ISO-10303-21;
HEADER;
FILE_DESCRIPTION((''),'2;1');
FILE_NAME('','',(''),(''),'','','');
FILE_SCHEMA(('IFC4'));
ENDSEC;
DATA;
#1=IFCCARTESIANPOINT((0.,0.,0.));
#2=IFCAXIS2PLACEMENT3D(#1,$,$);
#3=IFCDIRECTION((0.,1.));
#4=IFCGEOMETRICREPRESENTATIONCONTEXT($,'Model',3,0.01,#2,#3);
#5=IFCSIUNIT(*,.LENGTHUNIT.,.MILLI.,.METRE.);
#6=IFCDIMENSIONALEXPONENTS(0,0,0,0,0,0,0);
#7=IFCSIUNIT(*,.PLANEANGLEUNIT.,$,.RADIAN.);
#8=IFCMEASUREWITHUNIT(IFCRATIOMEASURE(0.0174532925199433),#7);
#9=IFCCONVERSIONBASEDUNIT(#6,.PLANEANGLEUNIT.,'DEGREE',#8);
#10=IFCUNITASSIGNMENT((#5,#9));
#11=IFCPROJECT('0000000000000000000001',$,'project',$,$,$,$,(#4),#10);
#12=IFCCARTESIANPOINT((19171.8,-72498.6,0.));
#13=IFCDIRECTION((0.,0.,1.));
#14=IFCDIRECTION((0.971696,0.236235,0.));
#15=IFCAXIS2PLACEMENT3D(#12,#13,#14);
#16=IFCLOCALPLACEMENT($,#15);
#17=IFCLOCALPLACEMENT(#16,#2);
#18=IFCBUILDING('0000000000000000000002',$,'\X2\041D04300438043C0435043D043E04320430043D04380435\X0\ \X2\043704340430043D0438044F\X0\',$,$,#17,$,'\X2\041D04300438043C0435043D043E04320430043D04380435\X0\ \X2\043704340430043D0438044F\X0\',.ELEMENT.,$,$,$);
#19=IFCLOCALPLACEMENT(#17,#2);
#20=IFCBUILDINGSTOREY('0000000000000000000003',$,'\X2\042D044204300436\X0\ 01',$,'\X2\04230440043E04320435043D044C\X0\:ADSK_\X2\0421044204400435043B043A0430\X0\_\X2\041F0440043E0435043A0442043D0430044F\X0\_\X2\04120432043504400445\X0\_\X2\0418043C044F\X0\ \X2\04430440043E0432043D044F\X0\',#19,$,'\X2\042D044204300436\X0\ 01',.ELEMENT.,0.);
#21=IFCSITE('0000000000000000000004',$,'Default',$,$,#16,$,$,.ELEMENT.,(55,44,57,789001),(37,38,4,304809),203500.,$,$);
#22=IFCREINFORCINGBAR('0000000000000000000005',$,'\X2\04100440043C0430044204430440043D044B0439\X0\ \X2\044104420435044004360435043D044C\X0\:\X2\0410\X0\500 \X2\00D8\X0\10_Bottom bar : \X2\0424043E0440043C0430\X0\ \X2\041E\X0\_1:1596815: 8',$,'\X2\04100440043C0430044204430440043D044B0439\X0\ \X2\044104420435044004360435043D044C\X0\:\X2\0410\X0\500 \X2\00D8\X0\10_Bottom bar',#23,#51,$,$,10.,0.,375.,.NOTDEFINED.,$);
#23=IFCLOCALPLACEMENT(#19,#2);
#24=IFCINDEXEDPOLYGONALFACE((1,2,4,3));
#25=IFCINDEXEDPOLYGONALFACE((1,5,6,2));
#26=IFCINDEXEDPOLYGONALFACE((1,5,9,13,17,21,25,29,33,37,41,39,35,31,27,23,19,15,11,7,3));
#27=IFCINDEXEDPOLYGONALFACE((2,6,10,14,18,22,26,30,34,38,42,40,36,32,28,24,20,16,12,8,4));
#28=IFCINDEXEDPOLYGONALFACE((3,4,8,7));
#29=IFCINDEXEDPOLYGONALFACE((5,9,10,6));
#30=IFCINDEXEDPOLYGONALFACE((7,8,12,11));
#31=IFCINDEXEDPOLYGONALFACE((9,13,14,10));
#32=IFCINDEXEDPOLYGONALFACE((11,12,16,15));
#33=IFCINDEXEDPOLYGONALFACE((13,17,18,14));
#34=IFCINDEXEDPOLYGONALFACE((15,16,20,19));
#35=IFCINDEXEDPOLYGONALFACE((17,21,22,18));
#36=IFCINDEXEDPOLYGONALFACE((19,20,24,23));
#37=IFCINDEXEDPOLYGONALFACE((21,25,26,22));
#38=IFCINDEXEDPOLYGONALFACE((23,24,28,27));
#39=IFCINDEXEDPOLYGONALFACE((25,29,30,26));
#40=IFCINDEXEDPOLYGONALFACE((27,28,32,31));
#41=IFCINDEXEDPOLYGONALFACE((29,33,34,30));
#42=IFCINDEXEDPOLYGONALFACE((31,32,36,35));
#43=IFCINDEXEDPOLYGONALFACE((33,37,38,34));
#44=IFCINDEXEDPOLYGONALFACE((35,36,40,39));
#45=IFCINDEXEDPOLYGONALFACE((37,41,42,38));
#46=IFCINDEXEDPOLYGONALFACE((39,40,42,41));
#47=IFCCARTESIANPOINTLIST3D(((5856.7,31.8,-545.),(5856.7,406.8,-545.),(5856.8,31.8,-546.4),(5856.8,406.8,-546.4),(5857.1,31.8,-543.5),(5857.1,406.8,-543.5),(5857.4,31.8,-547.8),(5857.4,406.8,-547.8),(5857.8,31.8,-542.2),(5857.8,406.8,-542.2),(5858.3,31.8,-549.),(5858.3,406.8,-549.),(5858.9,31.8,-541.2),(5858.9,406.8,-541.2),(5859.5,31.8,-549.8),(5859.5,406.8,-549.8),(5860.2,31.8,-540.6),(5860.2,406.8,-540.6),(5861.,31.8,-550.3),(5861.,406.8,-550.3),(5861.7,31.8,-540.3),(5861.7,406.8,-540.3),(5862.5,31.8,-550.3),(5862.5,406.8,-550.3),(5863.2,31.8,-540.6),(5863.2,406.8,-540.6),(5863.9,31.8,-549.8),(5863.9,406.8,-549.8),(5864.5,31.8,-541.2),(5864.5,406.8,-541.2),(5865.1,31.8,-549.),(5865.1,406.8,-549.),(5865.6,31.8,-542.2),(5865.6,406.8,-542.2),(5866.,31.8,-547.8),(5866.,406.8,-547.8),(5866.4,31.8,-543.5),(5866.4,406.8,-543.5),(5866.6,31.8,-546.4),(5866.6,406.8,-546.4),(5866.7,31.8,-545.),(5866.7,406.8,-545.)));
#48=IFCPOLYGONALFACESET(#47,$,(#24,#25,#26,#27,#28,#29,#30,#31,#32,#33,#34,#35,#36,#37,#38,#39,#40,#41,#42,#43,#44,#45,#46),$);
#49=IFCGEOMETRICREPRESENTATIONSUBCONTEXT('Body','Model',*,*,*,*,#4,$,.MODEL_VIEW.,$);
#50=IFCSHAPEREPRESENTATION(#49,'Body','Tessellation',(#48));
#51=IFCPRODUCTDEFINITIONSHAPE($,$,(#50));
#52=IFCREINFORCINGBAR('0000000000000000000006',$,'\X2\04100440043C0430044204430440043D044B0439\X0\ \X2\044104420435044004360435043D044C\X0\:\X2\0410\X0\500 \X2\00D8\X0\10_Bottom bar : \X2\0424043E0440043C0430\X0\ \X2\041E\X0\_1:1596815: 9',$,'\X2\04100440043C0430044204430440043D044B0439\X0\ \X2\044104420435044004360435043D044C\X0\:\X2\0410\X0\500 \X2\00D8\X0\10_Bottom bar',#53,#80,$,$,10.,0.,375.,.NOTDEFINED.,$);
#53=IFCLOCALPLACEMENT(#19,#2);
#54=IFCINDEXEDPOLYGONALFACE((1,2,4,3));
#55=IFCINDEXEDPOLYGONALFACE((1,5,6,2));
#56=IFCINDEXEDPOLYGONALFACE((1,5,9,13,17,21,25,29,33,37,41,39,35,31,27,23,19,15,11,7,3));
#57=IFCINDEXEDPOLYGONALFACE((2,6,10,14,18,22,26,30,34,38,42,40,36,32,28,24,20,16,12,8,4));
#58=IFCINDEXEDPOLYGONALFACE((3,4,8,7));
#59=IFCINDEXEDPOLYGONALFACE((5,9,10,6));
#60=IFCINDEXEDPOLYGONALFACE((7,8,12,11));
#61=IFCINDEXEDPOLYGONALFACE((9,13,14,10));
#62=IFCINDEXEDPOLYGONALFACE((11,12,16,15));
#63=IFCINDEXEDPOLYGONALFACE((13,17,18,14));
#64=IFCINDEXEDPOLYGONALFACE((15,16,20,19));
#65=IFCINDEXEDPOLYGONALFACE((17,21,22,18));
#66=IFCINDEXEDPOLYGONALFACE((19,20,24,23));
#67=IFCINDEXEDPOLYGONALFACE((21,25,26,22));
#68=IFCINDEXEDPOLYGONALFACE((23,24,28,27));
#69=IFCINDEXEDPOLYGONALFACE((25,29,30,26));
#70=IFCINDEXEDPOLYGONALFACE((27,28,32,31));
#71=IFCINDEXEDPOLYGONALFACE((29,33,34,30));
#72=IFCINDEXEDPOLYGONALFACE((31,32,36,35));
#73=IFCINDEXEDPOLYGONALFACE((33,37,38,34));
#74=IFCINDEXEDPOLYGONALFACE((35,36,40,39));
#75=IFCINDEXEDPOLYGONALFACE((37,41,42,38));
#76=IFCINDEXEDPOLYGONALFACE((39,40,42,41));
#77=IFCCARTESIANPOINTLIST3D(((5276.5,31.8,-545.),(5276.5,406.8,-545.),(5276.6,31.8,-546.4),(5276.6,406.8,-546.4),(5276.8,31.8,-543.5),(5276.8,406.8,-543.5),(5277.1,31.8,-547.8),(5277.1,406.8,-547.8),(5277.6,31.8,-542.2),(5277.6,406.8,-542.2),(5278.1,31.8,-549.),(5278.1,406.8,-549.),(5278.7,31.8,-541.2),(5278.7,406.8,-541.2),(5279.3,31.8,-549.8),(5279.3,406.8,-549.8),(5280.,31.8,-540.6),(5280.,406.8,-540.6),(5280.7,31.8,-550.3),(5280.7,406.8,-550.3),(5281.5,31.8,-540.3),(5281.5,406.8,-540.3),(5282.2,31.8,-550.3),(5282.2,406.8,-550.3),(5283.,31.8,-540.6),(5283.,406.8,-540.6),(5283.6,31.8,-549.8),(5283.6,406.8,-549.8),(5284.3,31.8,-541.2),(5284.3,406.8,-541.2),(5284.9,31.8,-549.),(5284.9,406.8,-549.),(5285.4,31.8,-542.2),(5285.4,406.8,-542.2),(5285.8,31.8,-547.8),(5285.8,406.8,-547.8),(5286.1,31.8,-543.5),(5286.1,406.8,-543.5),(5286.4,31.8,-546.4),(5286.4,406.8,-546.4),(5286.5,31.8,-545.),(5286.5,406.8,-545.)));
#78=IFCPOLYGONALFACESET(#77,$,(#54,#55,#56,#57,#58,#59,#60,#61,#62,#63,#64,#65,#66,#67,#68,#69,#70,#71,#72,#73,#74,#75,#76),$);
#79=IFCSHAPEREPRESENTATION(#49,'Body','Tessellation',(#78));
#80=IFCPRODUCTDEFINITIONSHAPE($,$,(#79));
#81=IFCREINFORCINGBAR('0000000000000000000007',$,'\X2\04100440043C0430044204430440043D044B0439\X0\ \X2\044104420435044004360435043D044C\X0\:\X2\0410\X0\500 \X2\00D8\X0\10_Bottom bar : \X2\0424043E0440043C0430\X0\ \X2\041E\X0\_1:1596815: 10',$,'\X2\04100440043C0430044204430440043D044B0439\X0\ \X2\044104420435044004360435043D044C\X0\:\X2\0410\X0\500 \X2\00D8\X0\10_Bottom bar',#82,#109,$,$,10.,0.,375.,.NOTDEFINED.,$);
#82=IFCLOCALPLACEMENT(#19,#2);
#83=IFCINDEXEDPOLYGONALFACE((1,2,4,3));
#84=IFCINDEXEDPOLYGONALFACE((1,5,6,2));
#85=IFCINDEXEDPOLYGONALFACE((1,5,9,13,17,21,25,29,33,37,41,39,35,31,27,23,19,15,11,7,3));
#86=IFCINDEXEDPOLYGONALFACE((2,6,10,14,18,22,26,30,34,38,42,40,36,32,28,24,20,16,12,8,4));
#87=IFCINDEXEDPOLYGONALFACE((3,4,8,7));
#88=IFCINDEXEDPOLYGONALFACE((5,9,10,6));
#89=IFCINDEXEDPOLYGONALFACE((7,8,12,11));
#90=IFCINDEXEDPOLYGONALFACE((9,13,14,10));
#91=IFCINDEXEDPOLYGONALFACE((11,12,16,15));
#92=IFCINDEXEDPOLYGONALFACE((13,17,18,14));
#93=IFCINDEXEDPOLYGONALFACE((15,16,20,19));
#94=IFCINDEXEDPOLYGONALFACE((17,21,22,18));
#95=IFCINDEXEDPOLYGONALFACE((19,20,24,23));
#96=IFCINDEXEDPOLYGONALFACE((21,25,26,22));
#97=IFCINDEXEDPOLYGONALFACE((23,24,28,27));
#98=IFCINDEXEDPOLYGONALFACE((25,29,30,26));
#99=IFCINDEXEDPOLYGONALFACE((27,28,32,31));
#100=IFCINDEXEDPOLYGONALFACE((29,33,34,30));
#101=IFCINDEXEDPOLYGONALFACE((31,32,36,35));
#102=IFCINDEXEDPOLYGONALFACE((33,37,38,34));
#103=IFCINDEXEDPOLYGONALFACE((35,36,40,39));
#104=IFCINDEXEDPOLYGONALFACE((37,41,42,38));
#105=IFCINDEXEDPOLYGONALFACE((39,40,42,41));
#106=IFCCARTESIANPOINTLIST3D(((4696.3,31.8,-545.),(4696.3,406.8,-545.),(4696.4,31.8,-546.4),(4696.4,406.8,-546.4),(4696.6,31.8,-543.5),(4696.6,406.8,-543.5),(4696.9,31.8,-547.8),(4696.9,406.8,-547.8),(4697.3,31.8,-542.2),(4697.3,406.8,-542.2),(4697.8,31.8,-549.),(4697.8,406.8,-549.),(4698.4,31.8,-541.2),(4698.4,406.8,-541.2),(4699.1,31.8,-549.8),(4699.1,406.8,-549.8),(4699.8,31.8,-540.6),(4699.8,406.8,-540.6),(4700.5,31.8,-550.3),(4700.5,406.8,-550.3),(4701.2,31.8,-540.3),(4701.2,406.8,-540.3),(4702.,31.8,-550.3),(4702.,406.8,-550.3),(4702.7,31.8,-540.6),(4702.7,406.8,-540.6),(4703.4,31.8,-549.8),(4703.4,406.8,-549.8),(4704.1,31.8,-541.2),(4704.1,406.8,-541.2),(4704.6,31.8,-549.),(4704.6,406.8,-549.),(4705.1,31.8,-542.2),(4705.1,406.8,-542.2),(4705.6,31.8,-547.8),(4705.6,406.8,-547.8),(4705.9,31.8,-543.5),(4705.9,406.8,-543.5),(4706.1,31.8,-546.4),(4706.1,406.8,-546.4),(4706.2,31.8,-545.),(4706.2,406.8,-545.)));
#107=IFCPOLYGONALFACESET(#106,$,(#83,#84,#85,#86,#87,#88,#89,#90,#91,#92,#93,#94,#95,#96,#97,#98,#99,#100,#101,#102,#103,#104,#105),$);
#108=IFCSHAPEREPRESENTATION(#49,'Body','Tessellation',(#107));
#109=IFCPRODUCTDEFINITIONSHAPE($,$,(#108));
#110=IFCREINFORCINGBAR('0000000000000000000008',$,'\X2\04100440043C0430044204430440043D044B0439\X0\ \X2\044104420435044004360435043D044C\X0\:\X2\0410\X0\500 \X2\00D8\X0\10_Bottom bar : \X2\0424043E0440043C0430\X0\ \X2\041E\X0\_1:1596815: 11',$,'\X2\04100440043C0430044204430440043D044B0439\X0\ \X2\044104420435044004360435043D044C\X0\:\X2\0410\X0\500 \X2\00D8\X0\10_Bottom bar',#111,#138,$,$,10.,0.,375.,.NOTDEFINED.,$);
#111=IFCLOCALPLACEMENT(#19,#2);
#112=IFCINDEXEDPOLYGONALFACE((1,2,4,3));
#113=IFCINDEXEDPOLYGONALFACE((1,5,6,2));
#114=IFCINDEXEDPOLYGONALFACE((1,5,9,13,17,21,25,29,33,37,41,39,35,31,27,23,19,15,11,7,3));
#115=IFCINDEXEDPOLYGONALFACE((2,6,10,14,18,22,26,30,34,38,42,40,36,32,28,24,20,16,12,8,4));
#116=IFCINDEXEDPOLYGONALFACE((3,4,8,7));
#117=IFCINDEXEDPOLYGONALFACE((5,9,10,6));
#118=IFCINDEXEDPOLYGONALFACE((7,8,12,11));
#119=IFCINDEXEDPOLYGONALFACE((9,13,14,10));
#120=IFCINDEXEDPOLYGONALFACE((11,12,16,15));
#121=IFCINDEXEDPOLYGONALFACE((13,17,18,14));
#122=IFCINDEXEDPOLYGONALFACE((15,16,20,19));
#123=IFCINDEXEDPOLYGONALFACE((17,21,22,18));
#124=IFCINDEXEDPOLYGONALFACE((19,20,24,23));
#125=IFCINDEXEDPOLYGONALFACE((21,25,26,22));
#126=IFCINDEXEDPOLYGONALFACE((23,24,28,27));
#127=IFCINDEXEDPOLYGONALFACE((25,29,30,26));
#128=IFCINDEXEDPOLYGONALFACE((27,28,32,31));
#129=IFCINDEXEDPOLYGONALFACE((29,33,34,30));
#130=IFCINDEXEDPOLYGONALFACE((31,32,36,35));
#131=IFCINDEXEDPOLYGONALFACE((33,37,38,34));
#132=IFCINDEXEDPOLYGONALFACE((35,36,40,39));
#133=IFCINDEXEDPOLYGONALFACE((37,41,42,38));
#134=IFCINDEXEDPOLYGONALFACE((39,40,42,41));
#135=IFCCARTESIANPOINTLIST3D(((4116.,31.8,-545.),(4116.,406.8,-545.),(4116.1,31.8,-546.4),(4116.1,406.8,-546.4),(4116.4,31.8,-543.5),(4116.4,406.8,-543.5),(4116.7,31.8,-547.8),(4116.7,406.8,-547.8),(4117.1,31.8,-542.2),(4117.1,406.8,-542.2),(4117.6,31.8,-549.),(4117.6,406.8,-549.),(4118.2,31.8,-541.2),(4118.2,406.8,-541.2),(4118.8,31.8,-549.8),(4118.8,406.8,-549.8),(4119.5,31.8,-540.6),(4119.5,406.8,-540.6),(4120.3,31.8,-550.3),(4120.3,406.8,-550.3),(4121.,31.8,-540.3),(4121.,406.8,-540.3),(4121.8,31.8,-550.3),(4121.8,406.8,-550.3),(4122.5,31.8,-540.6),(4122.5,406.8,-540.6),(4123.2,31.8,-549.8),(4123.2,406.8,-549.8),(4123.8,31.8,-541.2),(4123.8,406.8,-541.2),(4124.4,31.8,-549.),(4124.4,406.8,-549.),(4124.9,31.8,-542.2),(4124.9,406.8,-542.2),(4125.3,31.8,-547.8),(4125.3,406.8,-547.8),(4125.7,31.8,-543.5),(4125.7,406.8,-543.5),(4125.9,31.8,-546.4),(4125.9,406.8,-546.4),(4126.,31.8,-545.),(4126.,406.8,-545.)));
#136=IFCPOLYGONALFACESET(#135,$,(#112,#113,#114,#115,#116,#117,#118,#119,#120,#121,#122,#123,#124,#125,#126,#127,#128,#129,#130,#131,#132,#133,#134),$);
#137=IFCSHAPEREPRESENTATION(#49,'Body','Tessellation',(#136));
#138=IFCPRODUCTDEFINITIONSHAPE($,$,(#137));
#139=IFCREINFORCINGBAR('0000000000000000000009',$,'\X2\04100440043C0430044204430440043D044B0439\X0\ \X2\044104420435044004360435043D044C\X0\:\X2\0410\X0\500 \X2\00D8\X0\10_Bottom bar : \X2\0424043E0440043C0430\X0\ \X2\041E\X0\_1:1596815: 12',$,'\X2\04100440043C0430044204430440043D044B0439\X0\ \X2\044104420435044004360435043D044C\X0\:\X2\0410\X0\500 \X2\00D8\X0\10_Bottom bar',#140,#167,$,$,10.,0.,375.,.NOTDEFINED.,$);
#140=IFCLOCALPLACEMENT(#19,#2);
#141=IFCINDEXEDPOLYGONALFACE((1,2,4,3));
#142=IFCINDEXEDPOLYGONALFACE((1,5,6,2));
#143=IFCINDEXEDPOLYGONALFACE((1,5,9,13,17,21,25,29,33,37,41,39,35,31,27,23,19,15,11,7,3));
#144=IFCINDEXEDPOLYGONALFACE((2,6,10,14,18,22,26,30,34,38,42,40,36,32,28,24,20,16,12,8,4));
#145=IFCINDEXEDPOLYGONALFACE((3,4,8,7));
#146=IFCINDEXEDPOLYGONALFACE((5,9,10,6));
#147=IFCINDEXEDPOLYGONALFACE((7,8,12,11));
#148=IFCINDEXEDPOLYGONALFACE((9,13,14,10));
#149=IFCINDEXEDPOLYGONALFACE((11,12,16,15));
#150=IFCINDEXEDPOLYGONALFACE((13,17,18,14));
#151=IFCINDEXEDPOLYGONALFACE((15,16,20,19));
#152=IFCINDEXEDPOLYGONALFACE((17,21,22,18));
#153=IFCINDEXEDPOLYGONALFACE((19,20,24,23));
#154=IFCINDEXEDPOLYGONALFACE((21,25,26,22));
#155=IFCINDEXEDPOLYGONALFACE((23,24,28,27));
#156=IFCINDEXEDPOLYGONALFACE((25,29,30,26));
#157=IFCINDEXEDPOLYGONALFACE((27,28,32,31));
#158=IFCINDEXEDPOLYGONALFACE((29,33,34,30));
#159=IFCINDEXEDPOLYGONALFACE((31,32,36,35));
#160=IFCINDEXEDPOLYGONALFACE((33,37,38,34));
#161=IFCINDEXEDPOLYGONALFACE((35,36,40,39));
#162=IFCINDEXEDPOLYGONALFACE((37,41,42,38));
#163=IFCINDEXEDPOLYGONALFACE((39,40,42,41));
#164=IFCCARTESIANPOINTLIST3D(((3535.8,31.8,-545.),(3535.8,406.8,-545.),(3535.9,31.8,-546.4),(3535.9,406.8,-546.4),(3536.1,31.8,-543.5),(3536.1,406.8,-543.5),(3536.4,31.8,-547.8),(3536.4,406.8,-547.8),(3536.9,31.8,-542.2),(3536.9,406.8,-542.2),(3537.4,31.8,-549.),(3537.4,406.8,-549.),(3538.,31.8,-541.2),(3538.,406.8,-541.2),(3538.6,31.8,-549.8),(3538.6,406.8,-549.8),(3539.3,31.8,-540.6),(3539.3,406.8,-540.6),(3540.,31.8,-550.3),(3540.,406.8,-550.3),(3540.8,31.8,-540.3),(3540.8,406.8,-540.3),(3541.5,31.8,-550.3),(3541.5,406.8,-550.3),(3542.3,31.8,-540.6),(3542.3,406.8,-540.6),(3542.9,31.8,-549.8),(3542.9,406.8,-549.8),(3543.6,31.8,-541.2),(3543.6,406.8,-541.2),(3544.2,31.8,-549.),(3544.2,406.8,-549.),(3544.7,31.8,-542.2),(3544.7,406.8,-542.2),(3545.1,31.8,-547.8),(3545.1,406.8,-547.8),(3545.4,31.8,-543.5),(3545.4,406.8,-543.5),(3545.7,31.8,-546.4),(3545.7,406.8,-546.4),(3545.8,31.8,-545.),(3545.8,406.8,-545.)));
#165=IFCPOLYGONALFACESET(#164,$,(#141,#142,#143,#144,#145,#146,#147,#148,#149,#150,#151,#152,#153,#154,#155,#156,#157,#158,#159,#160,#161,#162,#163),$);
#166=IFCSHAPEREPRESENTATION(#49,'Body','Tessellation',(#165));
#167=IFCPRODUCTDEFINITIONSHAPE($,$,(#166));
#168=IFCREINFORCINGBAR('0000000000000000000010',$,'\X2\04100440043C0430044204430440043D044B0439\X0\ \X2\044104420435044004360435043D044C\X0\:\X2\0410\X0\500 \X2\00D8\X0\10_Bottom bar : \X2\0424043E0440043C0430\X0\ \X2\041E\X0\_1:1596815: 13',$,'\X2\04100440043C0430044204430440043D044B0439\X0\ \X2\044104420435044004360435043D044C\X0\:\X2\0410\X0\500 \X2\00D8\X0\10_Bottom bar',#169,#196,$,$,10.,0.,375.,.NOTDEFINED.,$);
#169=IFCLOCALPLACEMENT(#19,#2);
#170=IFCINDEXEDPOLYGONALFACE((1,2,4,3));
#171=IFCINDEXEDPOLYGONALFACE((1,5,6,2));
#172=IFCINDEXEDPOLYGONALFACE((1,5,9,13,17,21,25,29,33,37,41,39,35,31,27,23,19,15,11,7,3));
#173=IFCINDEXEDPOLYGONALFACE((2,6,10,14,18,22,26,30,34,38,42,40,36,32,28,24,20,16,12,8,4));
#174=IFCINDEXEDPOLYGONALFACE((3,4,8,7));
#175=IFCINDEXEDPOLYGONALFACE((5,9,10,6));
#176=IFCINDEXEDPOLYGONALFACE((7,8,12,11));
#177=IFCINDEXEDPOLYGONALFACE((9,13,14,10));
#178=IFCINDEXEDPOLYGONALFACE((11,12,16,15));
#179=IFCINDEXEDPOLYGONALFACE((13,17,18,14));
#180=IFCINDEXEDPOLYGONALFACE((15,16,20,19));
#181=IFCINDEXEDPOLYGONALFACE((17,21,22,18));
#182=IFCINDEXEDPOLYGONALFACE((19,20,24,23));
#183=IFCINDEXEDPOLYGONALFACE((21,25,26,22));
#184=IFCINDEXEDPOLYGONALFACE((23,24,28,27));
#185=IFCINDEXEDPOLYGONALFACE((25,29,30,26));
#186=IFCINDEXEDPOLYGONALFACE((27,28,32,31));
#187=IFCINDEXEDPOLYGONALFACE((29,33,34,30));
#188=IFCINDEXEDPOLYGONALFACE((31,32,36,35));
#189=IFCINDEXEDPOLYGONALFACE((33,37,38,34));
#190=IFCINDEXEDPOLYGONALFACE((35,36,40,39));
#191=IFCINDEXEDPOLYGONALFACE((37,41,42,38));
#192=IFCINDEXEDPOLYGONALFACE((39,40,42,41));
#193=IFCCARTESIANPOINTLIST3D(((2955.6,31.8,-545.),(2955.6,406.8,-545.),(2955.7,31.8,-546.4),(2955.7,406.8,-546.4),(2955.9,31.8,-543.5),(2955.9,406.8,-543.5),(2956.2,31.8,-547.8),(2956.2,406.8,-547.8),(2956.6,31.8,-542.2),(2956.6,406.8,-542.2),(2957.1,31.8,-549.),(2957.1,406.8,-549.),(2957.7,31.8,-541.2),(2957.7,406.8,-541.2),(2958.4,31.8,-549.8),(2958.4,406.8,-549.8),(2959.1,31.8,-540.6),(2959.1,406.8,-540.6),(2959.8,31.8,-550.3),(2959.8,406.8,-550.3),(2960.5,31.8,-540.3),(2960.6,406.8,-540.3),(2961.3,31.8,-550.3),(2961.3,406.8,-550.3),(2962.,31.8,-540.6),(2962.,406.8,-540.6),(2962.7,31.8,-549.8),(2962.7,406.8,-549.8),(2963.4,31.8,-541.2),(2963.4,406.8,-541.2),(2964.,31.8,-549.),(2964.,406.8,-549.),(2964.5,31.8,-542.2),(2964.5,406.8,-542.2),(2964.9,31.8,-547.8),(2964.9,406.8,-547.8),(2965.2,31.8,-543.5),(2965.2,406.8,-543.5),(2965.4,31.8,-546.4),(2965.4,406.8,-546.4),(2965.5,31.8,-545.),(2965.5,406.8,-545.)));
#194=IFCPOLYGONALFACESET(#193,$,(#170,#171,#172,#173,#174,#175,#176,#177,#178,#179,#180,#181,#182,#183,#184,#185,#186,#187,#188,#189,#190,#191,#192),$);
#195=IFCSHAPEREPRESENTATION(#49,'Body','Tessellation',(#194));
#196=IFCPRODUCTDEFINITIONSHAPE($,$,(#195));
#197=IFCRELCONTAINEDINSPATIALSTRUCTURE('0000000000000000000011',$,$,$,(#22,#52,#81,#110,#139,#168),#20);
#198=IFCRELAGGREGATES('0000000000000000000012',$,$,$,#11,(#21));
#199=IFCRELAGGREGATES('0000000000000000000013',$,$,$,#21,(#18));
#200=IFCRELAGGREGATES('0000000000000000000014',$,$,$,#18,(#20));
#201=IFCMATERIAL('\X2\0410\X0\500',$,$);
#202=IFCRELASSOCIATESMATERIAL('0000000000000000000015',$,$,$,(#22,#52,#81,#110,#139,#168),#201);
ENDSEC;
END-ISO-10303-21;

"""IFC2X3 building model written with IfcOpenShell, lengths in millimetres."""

from ifc_helpers import new_model, entity, si_unit, converted_unit, direction, frame, origin, place, context, subcontext, project, spatial, material, element, save


model = new_model("IFC2X3")

# Units and contexts
model_context = context("Model", 3, precision=0.01, world=origin(), true_north=direction((0.0, 1.0)))
body_context = subcontext(model_context, "Body", "Model", "MODEL_VIEW")
ifc_project = project(units=[si_unit("LENGTHUNIT", "METRE", prefix="MILLI"), converted_unit("PLANEANGLEUNIT", "DEGREE", entity("IfcRatioMeasure", 0.0174532925199433), si_unit("PLANEANGLEUNIT", "RADIAN"), dimensions=[0, 0, 0, 0, 0, 0, 0])], contexts=[model_context])

# Site, building, storey
site_placement = place(None, frame((19171.8, -72498.6, 0.0), z_axis=(0.0, 0.0, 1.0), x_axis=(0.971696, 0.236235, 0.0)))
site = spatial("IfcSite", under=ifc_project, at=site_placement, Name="Default", CompositionType="ELEMENT", RefLatitude=(55, 44, 57, 789001), RefLongitude=(37, 38, 4, 304809), RefElevation=203500.0)
building_placement = place(site_placement, origin())
building = spatial("IfcBuilding", under=site, at=building_placement, Name="Наименование здания", LongName="Наименование здания", CompositionType="ELEMENT")
storey_placement = place(building_placement, origin())
storey = spatial("IfcBuildingStorey", under=building, at=storey_placement, Name="Этаж 01", ObjectType="Уровень:ADSK_Стрелка_Проектная_Вверх_Имя уровня", LongName="Этаж 01", CompositionType="ELEMENT", Elevation=0.0)

# Reinforcing bars
ifc_material = material(Name="А500")
placement = place(storey_placement, origin())
element("IfcReinforcingBar", 1, at=placement, inside=storey, material=ifc_material, Name="Арматурный стержень:А500 Ø10_Bottom bar : Форма О_1:1596815: 8", ObjectType="Арматурный стержень:А500 Ø10_Bottom bar", BarLength=375.0, BarRole="NOTDEFINED", CrossSectionArea=0.0, NominalDiameter=10.0, context=body_context, shape_type="AdvancedSweptSolid", body=[
    entity("IfcSweptDiskSolid", entity("IfcCompositeCurve", [entity("IfcCompositeCurveSegment", "CONTINUOUS", True, entity("IfcPolyline", [entity("IfcCartesianPoint", [5861.7, 31.8, -545.3]), entity("IfcCartesianPoint", [5861.7, 406.8, -545.3])]))], False), 5.0, None, 0.0, 1.0),
])
element("IfcReinforcingBar", 2, at=placement, inside=storey, material=ifc_material, Name="Арматурный стержень:А500 Ø10_Bottom bar : Форма О_1:1596815: 9", ObjectType="Арматурный стержень:А500 Ø10_Bottom bar", BarLength=375.0, BarRole="NOTDEFINED", CrossSectionArea=0.0, NominalDiameter=10.0, context=body_context, shape_type="AdvancedSweptSolid", body=[
    entity("IfcSweptDiskSolid", entity("IfcCompositeCurve", [entity("IfcCompositeCurveSegment", "CONTINUOUS", True, entity("IfcPolyline", [entity("IfcCartesianPoint", [5281.5, 31.8, -545.3]), entity("IfcCartesianPoint", [5281.5, 406.8, -545.3])]))], False), 5.0, None, 0.0, 1.0),
])
element("IfcReinforcingBar", 3, at=placement, inside=storey, material=ifc_material, Name="Арматурный стержень:А500 Ø10_Bottom bar : Форма О_1:1596815: 10", ObjectType="Арматурный стержень:А500 Ø10_Bottom bar", BarLength=375.0, BarRole="NOTDEFINED", CrossSectionArea=0.0, NominalDiameter=10.0, context=body_context, shape_type="AdvancedSweptSolid", body=[
    entity("IfcSweptDiskSolid", entity("IfcCompositeCurve", [entity("IfcCompositeCurveSegment", "CONTINUOUS", True, entity("IfcPolyline", [entity("IfcCartesianPoint", [4701.2, 31.8, -545.3]), entity("IfcCartesianPoint", [4701.2, 406.8, -545.3])]))], False), 5.0, None, 0.0, 1.0),
])
element("IfcReinforcingBar", 4, at=placement, inside=storey, material=ifc_material, Name="Арматурный стержень:А500 Ø10_Bottom bar : Форма О_1:1596815: 11", ObjectType="Арматурный стержень:А500 Ø10_Bottom bar", BarLength=375.0, BarRole="NOTDEFINED", CrossSectionArea=0.0, NominalDiameter=10.0, context=body_context, shape_type="AdvancedSweptSolid", body=[
    entity("IfcSweptDiskSolid", entity("IfcCompositeCurve", [entity("IfcCompositeCurveSegment", "CONTINUOUS", True, entity("IfcPolyline", [entity("IfcCartesianPoint", [4121.0, 31.8, -545.3]), entity("IfcCartesianPoint", [4121.0, 406.8, -545.3])]))], False), 5.0, None, 0.0, 1.0),
])
element("IfcReinforcingBar", 5, at=placement, inside=storey, material=ifc_material, Name="Арматурный стержень:А500 Ø10_Bottom bar : Форма О_1:1596815: 12", ObjectType="Арматурный стержень:А500 Ø10_Bottom bar", BarLength=375.0, BarRole="NOTDEFINED", CrossSectionArea=0.0, NominalDiameter=10.0, context=body_context, shape_type="AdvancedSweptSolid", body=[
    entity("IfcSweptDiskSolid", entity("IfcCompositeCurve", [entity("IfcCompositeCurveSegment", "CONTINUOUS", True, entity("IfcPolyline", [entity("IfcCartesianPoint", [3540.8, 31.8, -545.3]), entity("IfcCartesianPoint", [3540.8, 406.8, -545.3])]))], False), 5.0, None, 0.0, 1.0),
])
element("IfcReinforcingBar", 6, at=placement, inside=storey, material=ifc_material, Name="Арматурный стержень:А500 Ø10_Bottom bar : Форма О_1:1596815: 13", ObjectType="Арматурный стержень:А500 Ø10_Bottom bar", BarLength=375.0, BarRole="NOTDEFINED", CrossSectionArea=0.0, NominalDiameter=10.0, context=body_context, shape_type="AdvancedSweptSolid", body=[
    entity("IfcSweptDiskSolid", entity("IfcCompositeCurve", [entity("IfcCompositeCurveSegment", "CONTINUOUS", True, entity("IfcPolyline", [entity("IfcCartesianPoint", [2960.6, 31.8, -545.3]), entity("IfcCartesianPoint", [2960.6, 406.8, -545.3])]))], False), 5.0, None, 0.0, 1.0),
])

save(model, "model.ifc")
